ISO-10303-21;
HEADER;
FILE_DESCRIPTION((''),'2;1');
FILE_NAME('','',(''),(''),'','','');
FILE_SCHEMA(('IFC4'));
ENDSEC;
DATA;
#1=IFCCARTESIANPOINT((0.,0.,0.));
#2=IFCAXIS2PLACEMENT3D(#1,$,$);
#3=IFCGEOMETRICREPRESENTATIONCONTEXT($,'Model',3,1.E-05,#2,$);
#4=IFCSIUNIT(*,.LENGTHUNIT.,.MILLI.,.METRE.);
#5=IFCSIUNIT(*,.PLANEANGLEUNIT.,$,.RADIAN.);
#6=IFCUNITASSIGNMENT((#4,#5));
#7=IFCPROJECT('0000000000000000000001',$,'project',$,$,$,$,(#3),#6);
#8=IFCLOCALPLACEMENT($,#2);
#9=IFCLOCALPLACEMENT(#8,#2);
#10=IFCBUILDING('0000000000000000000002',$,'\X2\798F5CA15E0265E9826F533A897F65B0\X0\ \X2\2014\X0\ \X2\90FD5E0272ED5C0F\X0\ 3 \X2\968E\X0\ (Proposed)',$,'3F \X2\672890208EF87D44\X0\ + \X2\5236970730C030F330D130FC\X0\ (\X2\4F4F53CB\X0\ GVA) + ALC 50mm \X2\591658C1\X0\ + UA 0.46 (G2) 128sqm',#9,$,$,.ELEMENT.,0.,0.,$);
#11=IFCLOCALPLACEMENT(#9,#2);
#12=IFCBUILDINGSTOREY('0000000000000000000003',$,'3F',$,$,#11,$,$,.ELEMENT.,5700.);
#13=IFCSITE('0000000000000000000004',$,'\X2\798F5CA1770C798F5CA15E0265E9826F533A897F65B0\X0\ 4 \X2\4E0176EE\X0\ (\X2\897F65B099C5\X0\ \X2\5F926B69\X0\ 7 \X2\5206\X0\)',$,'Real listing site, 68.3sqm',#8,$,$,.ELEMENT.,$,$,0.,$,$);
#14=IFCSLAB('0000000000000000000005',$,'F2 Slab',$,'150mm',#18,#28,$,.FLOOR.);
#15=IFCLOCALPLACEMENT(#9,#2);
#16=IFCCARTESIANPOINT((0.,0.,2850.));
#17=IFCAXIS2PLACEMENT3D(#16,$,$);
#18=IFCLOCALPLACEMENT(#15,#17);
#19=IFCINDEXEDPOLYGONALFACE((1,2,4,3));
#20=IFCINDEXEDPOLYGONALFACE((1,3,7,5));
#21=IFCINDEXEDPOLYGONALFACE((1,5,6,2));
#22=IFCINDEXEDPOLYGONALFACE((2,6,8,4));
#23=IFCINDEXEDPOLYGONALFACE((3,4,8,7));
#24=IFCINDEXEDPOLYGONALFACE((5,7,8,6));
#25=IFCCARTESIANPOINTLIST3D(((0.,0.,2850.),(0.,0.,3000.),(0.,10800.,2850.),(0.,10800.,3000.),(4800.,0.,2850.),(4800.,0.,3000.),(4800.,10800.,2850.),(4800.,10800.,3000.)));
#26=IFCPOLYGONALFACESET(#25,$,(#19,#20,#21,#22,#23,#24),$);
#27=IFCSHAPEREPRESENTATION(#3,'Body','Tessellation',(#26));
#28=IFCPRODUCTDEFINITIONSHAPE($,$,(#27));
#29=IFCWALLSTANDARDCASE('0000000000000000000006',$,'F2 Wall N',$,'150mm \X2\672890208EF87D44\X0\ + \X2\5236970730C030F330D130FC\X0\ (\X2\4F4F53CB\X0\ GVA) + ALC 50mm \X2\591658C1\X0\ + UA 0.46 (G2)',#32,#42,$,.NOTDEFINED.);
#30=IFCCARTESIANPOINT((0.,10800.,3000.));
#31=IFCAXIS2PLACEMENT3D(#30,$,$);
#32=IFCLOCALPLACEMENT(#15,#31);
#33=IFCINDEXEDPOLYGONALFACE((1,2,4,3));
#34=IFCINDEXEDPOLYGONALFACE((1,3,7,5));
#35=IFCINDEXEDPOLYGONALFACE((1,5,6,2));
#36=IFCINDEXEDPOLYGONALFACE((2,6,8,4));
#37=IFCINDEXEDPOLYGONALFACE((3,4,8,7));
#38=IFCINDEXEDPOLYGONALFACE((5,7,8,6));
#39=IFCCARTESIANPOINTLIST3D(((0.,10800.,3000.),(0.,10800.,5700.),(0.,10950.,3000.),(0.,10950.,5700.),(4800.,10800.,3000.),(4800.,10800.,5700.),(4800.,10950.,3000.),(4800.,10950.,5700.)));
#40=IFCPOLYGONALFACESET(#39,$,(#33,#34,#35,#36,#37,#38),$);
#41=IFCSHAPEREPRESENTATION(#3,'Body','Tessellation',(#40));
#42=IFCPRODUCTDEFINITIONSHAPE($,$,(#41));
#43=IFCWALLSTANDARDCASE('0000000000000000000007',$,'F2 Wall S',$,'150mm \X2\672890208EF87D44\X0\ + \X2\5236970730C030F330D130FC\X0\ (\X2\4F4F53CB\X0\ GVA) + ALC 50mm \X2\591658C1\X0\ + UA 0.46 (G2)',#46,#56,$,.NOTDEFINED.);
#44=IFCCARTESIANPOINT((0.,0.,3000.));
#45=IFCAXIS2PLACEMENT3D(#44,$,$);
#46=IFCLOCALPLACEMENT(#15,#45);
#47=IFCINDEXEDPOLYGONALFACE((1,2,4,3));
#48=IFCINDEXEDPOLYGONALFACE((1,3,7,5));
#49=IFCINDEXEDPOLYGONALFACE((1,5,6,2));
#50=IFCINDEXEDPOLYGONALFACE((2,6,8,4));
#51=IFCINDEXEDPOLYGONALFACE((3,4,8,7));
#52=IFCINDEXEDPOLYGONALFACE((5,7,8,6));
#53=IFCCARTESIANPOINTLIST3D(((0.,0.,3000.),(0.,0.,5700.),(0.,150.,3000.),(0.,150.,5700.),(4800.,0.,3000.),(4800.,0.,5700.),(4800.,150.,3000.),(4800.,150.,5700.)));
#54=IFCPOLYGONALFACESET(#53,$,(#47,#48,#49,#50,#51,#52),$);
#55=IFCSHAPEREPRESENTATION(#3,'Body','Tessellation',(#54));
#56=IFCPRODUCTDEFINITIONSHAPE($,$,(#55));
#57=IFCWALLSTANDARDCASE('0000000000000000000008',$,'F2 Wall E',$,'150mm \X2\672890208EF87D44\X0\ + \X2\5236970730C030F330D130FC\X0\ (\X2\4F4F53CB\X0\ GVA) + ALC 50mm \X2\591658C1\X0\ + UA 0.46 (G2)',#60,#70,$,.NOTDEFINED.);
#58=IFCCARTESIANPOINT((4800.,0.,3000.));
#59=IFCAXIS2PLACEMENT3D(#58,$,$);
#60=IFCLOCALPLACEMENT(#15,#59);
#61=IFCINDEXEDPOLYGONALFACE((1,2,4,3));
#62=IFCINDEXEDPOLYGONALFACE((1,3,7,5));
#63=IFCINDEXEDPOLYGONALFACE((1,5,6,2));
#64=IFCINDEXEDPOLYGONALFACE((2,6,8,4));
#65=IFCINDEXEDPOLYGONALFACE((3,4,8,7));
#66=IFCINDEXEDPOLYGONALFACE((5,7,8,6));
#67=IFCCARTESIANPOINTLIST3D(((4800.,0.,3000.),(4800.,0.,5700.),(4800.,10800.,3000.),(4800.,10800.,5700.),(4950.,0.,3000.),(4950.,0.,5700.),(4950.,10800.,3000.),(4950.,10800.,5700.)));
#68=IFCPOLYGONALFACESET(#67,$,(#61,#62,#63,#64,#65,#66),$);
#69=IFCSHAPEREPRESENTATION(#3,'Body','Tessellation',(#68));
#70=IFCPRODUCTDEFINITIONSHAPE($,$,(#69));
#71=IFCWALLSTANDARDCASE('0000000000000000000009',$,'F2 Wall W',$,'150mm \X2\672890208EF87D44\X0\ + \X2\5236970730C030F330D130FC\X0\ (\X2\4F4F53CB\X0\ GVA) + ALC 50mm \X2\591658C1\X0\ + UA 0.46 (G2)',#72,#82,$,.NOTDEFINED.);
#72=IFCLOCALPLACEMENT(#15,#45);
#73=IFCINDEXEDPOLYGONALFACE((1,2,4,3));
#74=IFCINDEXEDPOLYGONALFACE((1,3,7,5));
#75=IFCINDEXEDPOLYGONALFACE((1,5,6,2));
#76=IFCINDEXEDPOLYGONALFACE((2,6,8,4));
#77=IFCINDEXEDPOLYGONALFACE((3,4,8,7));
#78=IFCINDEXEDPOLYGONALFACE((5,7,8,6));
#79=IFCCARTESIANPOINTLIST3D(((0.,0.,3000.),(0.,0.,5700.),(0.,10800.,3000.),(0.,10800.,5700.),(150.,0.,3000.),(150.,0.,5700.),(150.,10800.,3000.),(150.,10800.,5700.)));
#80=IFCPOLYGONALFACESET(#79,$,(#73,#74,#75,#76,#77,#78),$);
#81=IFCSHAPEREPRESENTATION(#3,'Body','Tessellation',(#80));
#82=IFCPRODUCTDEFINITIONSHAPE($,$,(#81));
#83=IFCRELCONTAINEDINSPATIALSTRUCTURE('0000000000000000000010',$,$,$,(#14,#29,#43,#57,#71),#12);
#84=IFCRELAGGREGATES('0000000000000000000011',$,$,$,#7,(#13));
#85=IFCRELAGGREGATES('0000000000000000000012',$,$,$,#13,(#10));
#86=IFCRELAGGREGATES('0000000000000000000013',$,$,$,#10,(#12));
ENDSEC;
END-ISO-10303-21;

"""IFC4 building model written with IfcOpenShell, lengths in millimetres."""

from ifc_helpers import new_model, si_unit, frame, frame_2d, origin, place, context, project, spatial, rectangle, extrude, element, save


model = new_model("IFC4")

# Units and contexts
model_context = context("Model", 3, precision=1e-05, world=origin())
ifc_project = project(units=[si_unit("LENGTHUNIT", "METRE", prefix="MILLI"), si_unit("PLANEANGLEUNIT", "RADIAN")], contexts=[model_context])

# Site, building, storey
site_placement = place(None, origin())
site = spatial("IfcSite", under=ifc_project, at=site_placement, Name="福岡県福岡市早良区西新 4 丁目 (西新駅 徒歩 7 分)", ObjectType="Real listing site, 68.3sqm", CompositionType="ELEMENT", RefElevation=0.0)
building_placement = place(site_placement, origin())
building = spatial("IfcBuilding", under=site, at=building_placement, Name="福岡市早良区西新 — 都市狭小 3 階 (Proposed)", ObjectType="3F 木造軸組 + 制震ダンパー (住友 GVA) + ALC 50mm 外壁 + UA 0.46 (G2) 128sqm", CompositionType="ELEMENT", ElevationOfRefHeight=0.0, ElevationOfTerrain=0.0)
storey_placement = place(building_placement, origin())
storey = spatial("IfcBuildingStorey", under=building, at=storey_placement, Name="3F", CompositionType="ELEMENT", Elevation=5700.0)

# Slab
placement = place(building_placement, origin())
slab_placement = place(placement, frame((0.0, 0.0, 2850.0)))
element("IfcSlab", 1, at=slab_placement, inside=storey, Name="F2 Slab", ObjectType="150mm", PredefinedType="FLOOR", context=model_context, shape_type="SweptSolid", body=[
    extrude(rectangle(XDim=4800.0, YDim=10800.0, at=frame_2d((2400.0, 5400.0))), frame((0.0, 0.0, 2850.0)), (0.0, 0.0, 1.0), 150.0),
])

# Walls
wall_1_placement = place(placement, frame((0.0, 10800.0, 3000.0)))
element("IfcWallStandardCase", 2, at=wall_1_placement, inside=storey, Name="F2 Wall N", ObjectType="150mm 木造軸組 + 制震ダンパー (住友 GVA) + ALC 50mm 外壁 + UA 0.46 (G2)", PredefinedType="NOTDEFINED", context=model_context, shape_type="SweptSolid", body=[
    extrude(rectangle(XDim=4800.0, YDim=150.0, at=frame_2d((2400.0, 75.0))), frame((0.0, 10800.0, 3000.0)), (0.0, 0.0, 1.0), 2700.0),
])
wall_2_placement = place(placement, frame((0.0, 0.0, 3000.0)))
element("IfcWallStandardCase", 3, at=wall_2_placement, inside=storey, Name="F2 Wall S", ObjectType="150mm 木造軸組 + 制震ダンパー (住友 GVA) + ALC 50mm 外壁 + UA 0.46 (G2)", PredefinedType="NOTDEFINED", context=model_context, shape_type="SweptSolid", body=[
    extrude(rectangle(XDim=4800.0, YDim=150.0, at=frame_2d((2400.0, 75.0))), frame((0.0, 0.0, 3000.0)), (0.0, 0.0, 1.0), 2700.0),
])
wall_3_placement = place(placement, frame((4800.0, 0.0, 3000.0)))
element("IfcWallStandardCase", 4, at=wall_3_placement, inside=storey, Name="F2 Wall E", ObjectType="150mm 木造軸組 + 制震ダンパー (住友 GVA) + ALC 50mm 外壁 + UA 0.46 (G2)", PredefinedType="NOTDEFINED", context=model_context, shape_type="SweptSolid", body=[
    extrude(rectangle(XDim=150.0, YDim=10800.0, at=frame_2d((75.0, 5400.0))), frame((4800.0, 0.0, 3000.0)), (0.0, 0.0, 1.0), 2700.0),
])
wall_4_placement = place(placement, frame((0.0, 0.0, 3000.0)))
element("IfcWallStandardCase", 5, at=wall_4_placement, inside=storey, Name="F2 Wall W", ObjectType="150mm 木造軸組 + 制震ダンパー (住友 GVA) + ALC 50mm 外壁 + UA 0.46 (G2)", PredefinedType="NOTDEFINED", context=model_context, shape_type="SweptSolid", body=[
    extrude(rectangle(XDim=150.0, YDim=10800.0, at=frame_2d((75.0, 5400.0))), frame((0.0, 0.0, 3000.0)), (0.0, 0.0, 1.0), 2700.0),
])

save(model, "model.ifc")
